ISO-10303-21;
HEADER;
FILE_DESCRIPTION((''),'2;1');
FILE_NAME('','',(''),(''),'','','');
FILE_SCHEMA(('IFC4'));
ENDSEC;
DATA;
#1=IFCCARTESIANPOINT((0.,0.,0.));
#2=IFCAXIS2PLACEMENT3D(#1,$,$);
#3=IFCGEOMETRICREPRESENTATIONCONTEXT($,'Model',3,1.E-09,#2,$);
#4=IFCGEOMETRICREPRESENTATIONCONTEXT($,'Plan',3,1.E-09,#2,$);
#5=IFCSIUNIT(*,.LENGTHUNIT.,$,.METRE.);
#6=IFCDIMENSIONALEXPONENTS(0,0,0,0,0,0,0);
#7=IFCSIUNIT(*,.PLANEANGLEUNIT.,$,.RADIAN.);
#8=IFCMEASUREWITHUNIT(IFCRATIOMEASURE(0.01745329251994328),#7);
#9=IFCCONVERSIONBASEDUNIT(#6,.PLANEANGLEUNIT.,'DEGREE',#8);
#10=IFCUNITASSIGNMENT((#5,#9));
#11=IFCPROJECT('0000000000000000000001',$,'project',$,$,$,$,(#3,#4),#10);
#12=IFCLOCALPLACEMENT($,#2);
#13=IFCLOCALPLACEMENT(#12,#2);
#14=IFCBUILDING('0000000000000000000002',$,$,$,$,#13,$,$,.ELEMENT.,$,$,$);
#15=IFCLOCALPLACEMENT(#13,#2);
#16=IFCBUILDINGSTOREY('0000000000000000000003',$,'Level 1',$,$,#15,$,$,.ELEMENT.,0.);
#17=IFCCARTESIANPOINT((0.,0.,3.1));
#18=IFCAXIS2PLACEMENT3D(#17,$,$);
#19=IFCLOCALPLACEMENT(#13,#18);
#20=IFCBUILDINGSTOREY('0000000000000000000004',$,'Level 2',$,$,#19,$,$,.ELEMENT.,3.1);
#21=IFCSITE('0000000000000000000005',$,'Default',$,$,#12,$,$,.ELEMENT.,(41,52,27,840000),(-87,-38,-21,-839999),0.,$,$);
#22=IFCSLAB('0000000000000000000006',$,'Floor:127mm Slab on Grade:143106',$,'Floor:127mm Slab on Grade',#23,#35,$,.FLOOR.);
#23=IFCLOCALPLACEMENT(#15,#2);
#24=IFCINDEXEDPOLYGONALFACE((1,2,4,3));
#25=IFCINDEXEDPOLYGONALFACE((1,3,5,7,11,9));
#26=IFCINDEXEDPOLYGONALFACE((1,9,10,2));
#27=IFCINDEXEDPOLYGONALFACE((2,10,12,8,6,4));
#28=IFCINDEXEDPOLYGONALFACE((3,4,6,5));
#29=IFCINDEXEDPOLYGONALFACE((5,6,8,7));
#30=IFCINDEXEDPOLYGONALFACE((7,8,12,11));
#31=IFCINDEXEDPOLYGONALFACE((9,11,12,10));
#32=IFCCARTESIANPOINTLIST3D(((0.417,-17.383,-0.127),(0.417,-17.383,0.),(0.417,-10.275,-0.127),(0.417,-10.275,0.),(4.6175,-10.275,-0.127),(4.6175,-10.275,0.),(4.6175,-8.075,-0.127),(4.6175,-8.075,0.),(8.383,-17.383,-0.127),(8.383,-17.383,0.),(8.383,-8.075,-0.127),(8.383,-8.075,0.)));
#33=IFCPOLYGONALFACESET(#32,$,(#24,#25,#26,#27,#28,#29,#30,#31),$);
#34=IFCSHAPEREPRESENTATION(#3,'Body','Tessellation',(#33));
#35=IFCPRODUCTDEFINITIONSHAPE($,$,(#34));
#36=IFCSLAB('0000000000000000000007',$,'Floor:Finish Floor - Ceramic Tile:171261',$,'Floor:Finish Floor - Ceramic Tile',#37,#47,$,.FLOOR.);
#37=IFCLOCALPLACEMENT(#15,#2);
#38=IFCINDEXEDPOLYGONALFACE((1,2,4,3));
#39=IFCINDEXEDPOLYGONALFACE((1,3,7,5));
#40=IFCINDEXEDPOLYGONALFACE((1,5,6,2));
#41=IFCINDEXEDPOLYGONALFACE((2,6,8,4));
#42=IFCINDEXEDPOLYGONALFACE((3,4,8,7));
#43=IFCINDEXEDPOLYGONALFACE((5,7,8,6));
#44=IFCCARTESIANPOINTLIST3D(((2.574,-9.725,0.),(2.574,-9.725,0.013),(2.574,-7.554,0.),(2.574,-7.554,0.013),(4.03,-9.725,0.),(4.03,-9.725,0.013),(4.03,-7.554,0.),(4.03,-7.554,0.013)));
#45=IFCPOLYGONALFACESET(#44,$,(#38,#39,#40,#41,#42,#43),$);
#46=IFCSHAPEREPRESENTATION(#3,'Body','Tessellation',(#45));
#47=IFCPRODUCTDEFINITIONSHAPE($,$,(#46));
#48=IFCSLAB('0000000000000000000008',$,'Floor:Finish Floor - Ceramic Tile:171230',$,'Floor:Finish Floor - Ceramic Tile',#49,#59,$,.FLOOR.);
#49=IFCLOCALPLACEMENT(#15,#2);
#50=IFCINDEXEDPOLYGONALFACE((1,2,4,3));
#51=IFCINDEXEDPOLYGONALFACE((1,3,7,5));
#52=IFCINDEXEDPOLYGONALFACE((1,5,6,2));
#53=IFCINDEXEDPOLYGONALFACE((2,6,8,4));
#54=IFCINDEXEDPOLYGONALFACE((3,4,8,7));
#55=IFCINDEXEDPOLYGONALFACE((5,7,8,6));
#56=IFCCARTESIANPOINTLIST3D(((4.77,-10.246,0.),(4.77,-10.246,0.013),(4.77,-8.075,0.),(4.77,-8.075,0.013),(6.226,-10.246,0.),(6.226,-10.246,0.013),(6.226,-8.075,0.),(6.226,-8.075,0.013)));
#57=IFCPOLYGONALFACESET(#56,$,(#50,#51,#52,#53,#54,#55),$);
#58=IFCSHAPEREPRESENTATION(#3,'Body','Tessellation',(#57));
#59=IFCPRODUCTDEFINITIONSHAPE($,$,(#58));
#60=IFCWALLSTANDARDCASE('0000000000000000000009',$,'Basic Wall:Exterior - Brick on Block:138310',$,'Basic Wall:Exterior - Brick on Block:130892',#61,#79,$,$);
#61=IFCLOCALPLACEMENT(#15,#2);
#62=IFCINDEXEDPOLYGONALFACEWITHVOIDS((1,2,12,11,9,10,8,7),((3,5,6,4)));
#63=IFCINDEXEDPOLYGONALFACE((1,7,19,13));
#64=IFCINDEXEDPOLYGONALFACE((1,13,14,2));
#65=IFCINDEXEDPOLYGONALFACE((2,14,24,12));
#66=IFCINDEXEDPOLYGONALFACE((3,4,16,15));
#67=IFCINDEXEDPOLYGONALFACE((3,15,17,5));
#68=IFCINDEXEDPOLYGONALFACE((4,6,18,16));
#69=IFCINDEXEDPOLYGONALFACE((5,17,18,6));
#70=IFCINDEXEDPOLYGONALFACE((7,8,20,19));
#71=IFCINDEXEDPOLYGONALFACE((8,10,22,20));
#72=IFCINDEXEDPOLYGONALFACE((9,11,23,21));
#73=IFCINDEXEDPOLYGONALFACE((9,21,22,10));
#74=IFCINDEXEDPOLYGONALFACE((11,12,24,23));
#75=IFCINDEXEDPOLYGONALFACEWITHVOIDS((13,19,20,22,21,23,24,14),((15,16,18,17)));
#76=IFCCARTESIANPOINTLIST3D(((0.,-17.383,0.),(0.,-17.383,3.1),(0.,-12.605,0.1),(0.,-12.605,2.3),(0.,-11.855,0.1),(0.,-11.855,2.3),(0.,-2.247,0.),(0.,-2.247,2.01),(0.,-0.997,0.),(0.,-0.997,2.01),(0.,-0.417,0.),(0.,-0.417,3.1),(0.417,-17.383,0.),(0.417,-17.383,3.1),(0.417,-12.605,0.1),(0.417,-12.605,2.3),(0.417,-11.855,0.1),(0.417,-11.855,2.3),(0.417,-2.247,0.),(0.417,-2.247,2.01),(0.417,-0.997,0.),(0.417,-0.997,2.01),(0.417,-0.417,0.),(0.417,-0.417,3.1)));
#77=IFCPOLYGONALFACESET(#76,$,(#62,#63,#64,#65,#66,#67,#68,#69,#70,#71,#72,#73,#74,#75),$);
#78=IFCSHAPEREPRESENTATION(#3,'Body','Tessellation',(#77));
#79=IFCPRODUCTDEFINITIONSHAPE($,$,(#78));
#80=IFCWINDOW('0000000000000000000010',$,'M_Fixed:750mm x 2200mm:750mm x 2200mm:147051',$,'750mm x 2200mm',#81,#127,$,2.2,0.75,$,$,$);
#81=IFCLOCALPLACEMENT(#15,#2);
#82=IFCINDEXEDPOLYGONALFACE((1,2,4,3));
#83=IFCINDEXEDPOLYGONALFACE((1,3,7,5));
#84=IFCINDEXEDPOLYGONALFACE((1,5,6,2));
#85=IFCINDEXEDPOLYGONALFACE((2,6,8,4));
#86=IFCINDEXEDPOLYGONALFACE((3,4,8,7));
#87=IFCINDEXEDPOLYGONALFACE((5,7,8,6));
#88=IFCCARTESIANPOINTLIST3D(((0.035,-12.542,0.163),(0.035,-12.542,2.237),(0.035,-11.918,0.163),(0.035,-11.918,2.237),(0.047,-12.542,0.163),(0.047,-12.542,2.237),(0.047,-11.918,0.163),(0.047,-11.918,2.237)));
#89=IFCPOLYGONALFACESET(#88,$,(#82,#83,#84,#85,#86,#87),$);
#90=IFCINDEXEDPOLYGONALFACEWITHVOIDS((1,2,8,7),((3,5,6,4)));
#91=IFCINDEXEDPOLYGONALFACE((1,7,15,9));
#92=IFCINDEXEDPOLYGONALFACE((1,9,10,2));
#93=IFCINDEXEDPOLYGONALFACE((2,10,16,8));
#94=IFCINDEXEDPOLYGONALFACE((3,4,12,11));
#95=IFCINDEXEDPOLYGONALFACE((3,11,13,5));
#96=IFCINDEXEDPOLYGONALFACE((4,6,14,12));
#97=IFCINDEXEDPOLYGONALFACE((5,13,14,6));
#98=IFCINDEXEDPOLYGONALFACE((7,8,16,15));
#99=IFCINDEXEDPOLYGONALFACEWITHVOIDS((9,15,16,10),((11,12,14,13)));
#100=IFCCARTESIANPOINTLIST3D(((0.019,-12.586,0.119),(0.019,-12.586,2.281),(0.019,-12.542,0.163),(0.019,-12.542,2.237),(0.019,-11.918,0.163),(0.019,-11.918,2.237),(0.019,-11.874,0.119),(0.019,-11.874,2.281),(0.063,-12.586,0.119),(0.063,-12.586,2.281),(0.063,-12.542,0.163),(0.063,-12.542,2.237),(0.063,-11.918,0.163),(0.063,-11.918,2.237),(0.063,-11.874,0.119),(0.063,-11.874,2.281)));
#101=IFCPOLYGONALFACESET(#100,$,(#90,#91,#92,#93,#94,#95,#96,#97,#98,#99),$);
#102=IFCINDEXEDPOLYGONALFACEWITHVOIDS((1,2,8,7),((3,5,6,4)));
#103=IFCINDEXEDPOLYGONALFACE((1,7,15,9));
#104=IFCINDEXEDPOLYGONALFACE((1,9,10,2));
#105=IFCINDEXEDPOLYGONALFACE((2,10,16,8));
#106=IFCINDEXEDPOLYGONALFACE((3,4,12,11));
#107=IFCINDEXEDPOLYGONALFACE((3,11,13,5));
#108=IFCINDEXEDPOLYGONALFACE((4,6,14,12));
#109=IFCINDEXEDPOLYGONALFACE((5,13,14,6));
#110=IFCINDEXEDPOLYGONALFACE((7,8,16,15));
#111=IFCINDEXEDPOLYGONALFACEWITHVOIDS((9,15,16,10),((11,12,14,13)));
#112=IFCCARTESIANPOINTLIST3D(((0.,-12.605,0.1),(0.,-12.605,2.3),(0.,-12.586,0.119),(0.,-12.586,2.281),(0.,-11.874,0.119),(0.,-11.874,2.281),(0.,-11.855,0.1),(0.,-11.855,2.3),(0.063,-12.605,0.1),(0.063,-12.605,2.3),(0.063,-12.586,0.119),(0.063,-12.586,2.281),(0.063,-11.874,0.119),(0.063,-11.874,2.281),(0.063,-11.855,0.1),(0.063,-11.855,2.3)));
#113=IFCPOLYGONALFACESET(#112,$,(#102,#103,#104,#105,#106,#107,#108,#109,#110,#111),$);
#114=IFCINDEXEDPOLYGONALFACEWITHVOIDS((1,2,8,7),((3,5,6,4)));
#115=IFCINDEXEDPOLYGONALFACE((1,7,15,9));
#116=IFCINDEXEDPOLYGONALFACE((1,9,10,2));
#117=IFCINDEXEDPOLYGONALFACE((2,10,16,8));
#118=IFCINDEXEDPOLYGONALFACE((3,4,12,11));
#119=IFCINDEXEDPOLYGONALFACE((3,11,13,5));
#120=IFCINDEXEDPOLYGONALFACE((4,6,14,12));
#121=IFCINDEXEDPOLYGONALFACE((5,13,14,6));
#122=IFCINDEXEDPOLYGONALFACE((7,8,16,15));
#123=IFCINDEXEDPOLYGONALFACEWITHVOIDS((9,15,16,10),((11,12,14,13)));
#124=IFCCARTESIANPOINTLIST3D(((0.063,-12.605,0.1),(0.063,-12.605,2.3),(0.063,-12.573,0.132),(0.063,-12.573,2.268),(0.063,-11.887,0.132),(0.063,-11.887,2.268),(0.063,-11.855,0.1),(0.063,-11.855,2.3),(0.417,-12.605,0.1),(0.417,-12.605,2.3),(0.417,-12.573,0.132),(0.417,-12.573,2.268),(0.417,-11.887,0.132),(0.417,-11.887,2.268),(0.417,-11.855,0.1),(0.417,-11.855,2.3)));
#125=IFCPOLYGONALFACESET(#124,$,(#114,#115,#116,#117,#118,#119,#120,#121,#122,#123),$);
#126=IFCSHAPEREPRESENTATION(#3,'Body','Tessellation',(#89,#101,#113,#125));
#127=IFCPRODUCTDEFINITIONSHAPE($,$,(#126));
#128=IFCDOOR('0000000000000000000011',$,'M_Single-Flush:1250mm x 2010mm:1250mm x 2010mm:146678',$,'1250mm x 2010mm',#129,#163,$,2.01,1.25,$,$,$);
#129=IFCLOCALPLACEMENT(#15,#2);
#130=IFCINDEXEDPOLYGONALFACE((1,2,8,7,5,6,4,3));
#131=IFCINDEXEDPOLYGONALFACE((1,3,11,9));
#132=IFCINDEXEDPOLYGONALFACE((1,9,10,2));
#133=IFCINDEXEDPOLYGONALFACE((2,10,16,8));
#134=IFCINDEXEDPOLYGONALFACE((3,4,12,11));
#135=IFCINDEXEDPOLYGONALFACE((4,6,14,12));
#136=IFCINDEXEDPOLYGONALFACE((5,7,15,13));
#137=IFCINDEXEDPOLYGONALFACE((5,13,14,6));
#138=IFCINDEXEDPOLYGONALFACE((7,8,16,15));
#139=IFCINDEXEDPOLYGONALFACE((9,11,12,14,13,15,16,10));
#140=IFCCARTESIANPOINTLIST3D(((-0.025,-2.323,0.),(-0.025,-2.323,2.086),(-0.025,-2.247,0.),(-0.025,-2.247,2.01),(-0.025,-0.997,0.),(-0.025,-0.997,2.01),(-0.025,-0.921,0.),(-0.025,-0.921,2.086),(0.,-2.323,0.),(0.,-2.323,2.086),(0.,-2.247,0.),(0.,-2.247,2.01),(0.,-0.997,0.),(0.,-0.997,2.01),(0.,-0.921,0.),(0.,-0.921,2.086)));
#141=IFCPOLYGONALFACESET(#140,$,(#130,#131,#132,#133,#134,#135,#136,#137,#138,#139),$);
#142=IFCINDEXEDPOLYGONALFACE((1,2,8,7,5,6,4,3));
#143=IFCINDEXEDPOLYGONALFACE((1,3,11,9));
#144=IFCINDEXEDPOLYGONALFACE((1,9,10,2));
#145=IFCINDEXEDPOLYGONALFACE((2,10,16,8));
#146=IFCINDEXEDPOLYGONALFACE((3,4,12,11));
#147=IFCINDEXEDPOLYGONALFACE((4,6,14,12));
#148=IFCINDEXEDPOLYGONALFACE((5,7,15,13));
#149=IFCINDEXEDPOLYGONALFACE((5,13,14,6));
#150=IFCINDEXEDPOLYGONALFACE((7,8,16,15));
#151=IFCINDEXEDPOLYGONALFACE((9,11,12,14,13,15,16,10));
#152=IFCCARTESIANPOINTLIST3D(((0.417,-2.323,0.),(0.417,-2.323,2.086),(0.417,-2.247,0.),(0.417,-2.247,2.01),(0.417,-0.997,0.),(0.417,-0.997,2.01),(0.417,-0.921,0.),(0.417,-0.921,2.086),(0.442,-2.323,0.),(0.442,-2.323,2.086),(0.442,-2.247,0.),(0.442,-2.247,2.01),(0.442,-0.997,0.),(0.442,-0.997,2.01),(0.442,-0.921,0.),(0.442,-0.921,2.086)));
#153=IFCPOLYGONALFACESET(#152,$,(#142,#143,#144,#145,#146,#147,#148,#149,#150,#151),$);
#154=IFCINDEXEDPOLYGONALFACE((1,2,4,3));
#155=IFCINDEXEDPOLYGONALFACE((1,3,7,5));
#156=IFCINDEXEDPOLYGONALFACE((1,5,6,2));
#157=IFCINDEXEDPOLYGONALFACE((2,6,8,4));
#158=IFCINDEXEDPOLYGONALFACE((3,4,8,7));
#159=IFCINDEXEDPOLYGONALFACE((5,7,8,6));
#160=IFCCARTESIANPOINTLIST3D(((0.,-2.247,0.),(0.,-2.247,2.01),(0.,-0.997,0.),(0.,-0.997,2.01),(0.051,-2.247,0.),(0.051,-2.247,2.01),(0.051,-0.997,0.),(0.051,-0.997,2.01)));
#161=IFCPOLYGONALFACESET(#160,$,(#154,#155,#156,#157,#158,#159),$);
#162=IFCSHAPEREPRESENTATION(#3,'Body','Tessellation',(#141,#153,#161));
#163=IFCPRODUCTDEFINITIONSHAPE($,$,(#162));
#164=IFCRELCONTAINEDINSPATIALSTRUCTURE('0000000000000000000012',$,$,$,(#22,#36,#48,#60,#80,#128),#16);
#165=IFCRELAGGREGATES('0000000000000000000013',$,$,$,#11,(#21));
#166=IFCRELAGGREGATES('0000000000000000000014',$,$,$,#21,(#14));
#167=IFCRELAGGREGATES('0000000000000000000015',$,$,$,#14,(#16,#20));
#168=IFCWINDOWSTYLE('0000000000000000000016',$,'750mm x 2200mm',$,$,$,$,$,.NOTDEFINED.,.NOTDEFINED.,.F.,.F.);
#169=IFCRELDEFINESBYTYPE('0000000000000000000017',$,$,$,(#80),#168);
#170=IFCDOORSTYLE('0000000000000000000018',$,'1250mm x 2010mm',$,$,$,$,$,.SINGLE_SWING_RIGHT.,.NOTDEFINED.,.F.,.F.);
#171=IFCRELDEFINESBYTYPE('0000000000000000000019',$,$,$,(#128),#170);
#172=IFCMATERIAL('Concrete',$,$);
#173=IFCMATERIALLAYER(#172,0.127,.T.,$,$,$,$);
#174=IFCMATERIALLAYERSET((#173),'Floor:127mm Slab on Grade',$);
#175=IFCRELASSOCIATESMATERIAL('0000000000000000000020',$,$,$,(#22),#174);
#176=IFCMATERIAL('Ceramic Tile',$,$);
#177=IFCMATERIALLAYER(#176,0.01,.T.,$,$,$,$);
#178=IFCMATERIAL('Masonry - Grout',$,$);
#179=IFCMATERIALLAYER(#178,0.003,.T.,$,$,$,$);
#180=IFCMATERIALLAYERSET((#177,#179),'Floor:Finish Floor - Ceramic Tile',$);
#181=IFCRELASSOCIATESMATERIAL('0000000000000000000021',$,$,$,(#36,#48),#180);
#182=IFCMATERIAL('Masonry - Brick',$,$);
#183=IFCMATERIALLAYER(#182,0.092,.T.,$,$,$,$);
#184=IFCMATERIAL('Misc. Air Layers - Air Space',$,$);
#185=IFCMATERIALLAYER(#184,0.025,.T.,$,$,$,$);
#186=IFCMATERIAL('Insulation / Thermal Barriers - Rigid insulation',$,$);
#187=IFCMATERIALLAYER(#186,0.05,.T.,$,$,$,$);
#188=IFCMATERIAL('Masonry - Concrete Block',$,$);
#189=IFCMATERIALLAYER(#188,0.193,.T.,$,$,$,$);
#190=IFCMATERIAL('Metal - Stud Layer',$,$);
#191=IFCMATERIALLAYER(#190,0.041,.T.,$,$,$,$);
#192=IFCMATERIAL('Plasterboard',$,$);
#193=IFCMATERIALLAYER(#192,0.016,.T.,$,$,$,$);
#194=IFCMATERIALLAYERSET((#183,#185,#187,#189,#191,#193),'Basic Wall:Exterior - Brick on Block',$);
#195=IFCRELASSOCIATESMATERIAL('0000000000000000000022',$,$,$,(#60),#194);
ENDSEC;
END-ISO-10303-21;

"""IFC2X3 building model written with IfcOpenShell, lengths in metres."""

from ifc_helpers import new_model, entity, si_unit, converted_unit, frame, frame_2d, origin, origin_2d_with_axis, place, context, project, spatial, polyline, rectangle, outline, extrude, source, transform, mapped, material, layer, layer_set, layer_usage, type_object, type_shapes, element, fill, save


model = new_model("IFC2X3")

# Units and contexts
model_context = context("Model", 3, precision=1e-09, world=origin())
plan_context = context("Plan", 3, precision=1e-09, world=origin())
ifc_project = project(units=[si_unit("LENGTHUNIT", "METRE"), converted_unit("PLANEANGLEUNIT", "DEGREE", entity("IfcRatioMeasure", 0.01745329251994328), si_unit("PLANEANGLEUNIT", "RADIAN"), dimensions=[0, 0, 0, 0, 0, 0, 0])], contexts=[model_context, plan_context])

# Site, building, storey
site_placement = place(None, origin())
site = spatial("IfcSite", under=ifc_project, at=site_placement, Name="Default", CompositionType="ELEMENT", RefLatitude=(41, 52, 27, 840000), RefLongitude=(-87, -38, -21, -839999), RefElevation=0.0)
building_placement = place(site_placement, origin())
building = spatial("IfcBuilding", under=site, at=building_placement, CompositionType="ELEMENT")
storey_1_placement = place(building_placement, origin())
storey_1 = spatial("IfcBuildingStorey", under=building, at=storey_1_placement, Name="Level 1", CompositionType="ELEMENT", Elevation=0.0)

# Slabs
ifc_material_1 = material(Name="Concrete")
ifc_layer_1 = layer(ifc_material_1, 0.127, ventilated=True)
ifc_layer_set_1 = layer_set([ifc_layer_1], Name="Floor:127mm Slab on Grade")
ifc_layer_usage_1 = layer_usage(ifc_layer_set_1, "AXIS3", "POSITIVE", 0.0)
ifc_material_2 = material(Name="Ceramic Tile")
ifc_layer_2 = layer(ifc_material_2, 0.01, ventilated=True)
ifc_material_3 = material(Name="Masonry - Grout")
ifc_layer_3 = layer(ifc_material_3, 0.003, ventilated=True)
ifc_layer_set_2 = layer_set([ifc_layer_2, ifc_layer_3], Name="Floor:Finish Floor - Ceramic Tile")
ifc_layer_usage_2 = layer_usage(ifc_layer_set_2, "AXIS3", "POSITIVE", 0.0)
slab_1_placement = place(storey_1_placement, frame((0.417, -17.383, -0.127)))
element("IfcSlab", 1, at=slab_1_placement, inside=storey_1, material=ifc_layer_usage_1, Name="Floor:127mm Slab on Grade:143106", ObjectType="Floor:127mm Slab on Grade", PredefinedType="FLOOR", context=model_context, shape_type="SweptSolid", body=[
    extrude(outline(polyline([(-3.983, 4.654), (-3.983, -4.654), (3.983, -4.654), (3.983, 2.454), (-0.2175, 2.454), (-0.2175, 4.654), (-3.983, 4.654)])), frame((3.983, 4.654, 0.127), z_axis=(0.0, 0.0, -1.0), x_axis=(-1.0, 0.0, 0.0)), (0.0, 0.0, 1.0), 0.127),
])
slab_2_placement = place(storey_1_placement, frame((2.574, -9.725, 0.0)))
element("IfcSlab", 2, at=slab_2_placement, inside=storey_1, material=ifc_layer_usage_2, Name="Floor:Finish Floor - Ceramic Tile:171261", ObjectType="Floor:Finish Floor - Ceramic Tile", PredefinedType="FLOOR", context=model_context, shape_type="SweptSolid", body=[
    extrude(rectangle(XDim=2.171, YDim=1.456, at=frame_2d((0.0, 0.0), x_axis=(0.0, -1.0))), frame((0.728, 1.0855, 0.013), z_axis=(0.0, 0.0, -1.0), x_axis=(-1.0, 0.0, 0.0)), (0.0, 0.0, 1.0), 0.013),
])
slab_3_placement = place(storey_1_placement, frame((4.77, -10.246, 0.0)))
element("IfcSlab", 3, at=slab_3_placement, inside=storey_1, material=ifc_layer_usage_2, Name="Floor:Finish Floor - Ceramic Tile:171230", ObjectType="Floor:Finish Floor - Ceramic Tile", PredefinedType="FLOOR", context=model_context, shape_type="SweptSolid", body=[
    extrude(rectangle(XDim=1.456, YDim=2.171, at=frame_2d((0.0, 0.0), x_axis=(-1.0, 0.0))), frame((0.728, 1.0855, 0.013), z_axis=(0.0, 0.0, -1.0), x_axis=(-1.0, 0.0, 0.0)), (0.0, 0.0, 1.0), 0.013),
])

# Wall, openings, window, door
ifc_material_4 = material(Name="Masonry - Brick")
ifc_layer_4 = layer(ifc_material_4, 0.092, ventilated=True)
ifc_material_5 = material(Name="Misc. Air Layers - Air Space")
ifc_layer_5 = layer(ifc_material_5, 0.025, ventilated=True)
ifc_material_6 = material(Name="Insulation / Thermal Barriers - Rigid insulation")
ifc_layer_6 = layer(ifc_material_6, 0.05, ventilated=True)
ifc_material_7 = material(Name="Masonry - Concrete Block")
ifc_layer_7 = layer(ifc_material_7, 0.193, ventilated=True)
ifc_material_8 = material(Name="Metal - Stud Layer")
ifc_layer_8 = layer(ifc_material_8, 0.041, ventilated=True)
ifc_material_9 = material(Name="Plasterboard")
ifc_layer_9 = layer(ifc_material_9, 0.016, ventilated=True)
ifc_layer_set_3 = layer_set([ifc_layer_4, ifc_layer_5, ifc_layer_6, ifc_layer_7, ifc_layer_8, ifc_layer_9], Name="Basic Wall:Exterior - Brick on Block")
ifc_layer_usage_3 = layer_usage(ifc_layer_set_3, "AXIS2", "NEGATIVE", 0.2085)
wall_1_placement = place(storey_1_placement, frame((0.2085, -17.383, 0.0), z_axis=(0.0, 0.0, 1.0), x_axis=(0.0, 1.0, 0.0)))
wall_1 = element("IfcWallStandardCase", 4, at=wall_1_placement, inside=storey_1, material=ifc_layer_usage_3, Name="Basic Wall:Exterior - Brick on Block:138310", ObjectType="Basic Wall:Exterior - Brick on Block:130892", context=model_context, shape_type="SweptSolid", body=[
    extrude(rectangle(XDim=16.966, YDim=0.417, at=frame_2d((8.483, 0.0), x_axis=(-1.0, 0.0))), origin(), (0.0, 0.0, 1.0), 3.1),
])
opening_1_placement = place(wall_1_placement, frame((15.136, -0.2085, 0.0)))
opening_1 = element("IfcOpeningElement", 5, at=opening_1_placement, cuts=wall_1, ObjectType="Opening", context=model_context, shape_type="SweptSolid", body=[
    extrude(rectangle(XDim=1.25, YDim=2.01, at=frame_2d((1.005, 0.625), x_axis=(0.0, 1.0))), frame((0.0, 0.0, 0.0), z_axis=(0.0, 1.0, 0.0), x_axis=(0.0, 0.0, 1.0)), (0.0, 0.0, 1.0), 0.417),
])
opening_2_placement = place(wall_1_placement, frame((4.778, -0.2085, 0.1)))
opening_2 = element("IfcOpeningElement", 6, at=opening_2_placement, cuts=wall_1, ObjectType="Opening", context=model_context, shape_type="SweptSolid", body=[
    extrude(rectangle(XDim=2.2, YDim=0.75, at=frame_2d((1.1, 0.375), x_axis=(1.0, 0.0))), frame((0.0, 0.0, 0.0), z_axis=(0.0, 1.0, 0.0), x_axis=(0.0, 0.0, 1.0)), (0.0, 0.0, 1.0), 0.417),
])
window_style_1 = type_object("IfcWindowStyle", Name="750mm x 2200mm", ConstructionType="NOTDEFINED", OperationType="NOTDEFINED", ParameterTakesPrecedence=False, Sizeable=False)
shared_shape_1 = source(origin(), model_context, "Body", "SweptSolid", [
    extrude(rectangle(XDim=0.012, YDim=0.624, at=origin_2d_with_axis()), frame((0.375, 0.376, 0.063), z_axis=(0.0, 0.0, 1.0), x_axis=(0.0, -1.0, 0.0)), (0.0, 0.0, 1.0), 2.074),
    extrude(outline(polyline([(-0.356, -1.081), (0.356, -1.081), (0.356, 1.081), (-0.356, 1.081), (-0.356, -1.081)]), holes=[polyline([(-0.312, -1.037), (-0.312, 1.037), (0.312, 1.037), (0.312, -1.037), (-0.312, -1.037)])]), frame((0.375, 0.354, 1.1), z_axis=(0.0, 1.0, 0.0), x_axis=(1.0, 0.0, 0.0)), (0.0, 0.0, 1.0), 0.044),
    extrude(outline(polyline([(-0.375, -1.1), (0.375, -1.1), (0.375, 1.1), (-0.375, 1.1), (-0.375, -1.1)]), holes=[polyline([(-0.356, -1.081), (-0.356, 1.081), (0.356, 1.081), (0.356, -1.081), (-0.356, -1.081)])]), frame((0.375, 0.354, 1.1), z_axis=(0.0, 1.0, 0.0), x_axis=(1.0, 0.0, 0.0)), (0.0, 0.0, 1.0), 0.063),
    extrude(outline(polyline([(-0.375, -1.1), (0.375, -1.1), (0.375, 1.1), (-0.375, 1.1), (-0.375, -1.1)]), holes=[polyline([(-0.343, -1.068), (-0.343, 1.068), (0.343, 1.068), (0.343, -1.068), (-0.343, -1.068)])]), frame((0.375, 0.0, 1.1), z_axis=(0.0, 1.0, 0.0), x_axis=(1.0, 0.0, 0.0)), (0.0, 0.0, 1.0), 0.354),
])
type_shapes(window_style_1, [shared_shape_1])
window_1_placement = place(opening_2_placement, origin())
window_1 = element("IfcWindow", 7, at=window_1_placement, inside=storey_1, type_object=window_style_1, Name="M_Fixed:750mm x 2200mm:750mm x 2200mm:147051", ObjectType="750mm x 2200mm", OverallHeight=2.2, OverallWidth=0.75, context=model_context, shape_type="MappedRepresentation", body=[
    mapped(shared_shape_1, transform((0.0, 0.0, 0.0), scale=1.0)),
])
fill(opening_2, window_1)
door_style_1 = type_object("IfcDoorStyle", Name="1250mm x 2010mm", ConstructionType="NOTDEFINED", OperationType="SINGLE_SWING_RIGHT", ParameterTakesPrecedence=False, Sizeable=False)
shared_shape_2 = source(origin(), model_context, "Body", "SweptSolid", [
    extrude(outline(polyline([(-0.701, -1.062), (0.701, -1.062), (0.701, 1.024), (0.625, 1.024), (0.625, -0.986), (-0.625, -0.986), (-0.625, 1.024), (-0.701, 1.024), (-0.701, -1.062)])), frame((0.625, 0.417, 1.024), z_axis=(0.0, 1.0, 0.0), x_axis=(1.0, 0.0, 0.0)), (0.0, 0.0, 1.0), 0.025),
    extrude(outline(polyline([(-1.062, -0.701), (1.024, -0.701), (1.024, -0.625), (-0.986, -0.625), (-0.986, 0.625), (1.024, 0.625), (1.024, 0.701), (-1.062, 0.701), (-1.062, -0.701)])), frame((0.625, -0.025, 1.024), z_axis=(0.0, 1.0, 0.0), x_axis=(0.0, 0.0, -1.0)), (0.0, 0.0, 1.0), 0.025),
    extrude(rectangle(XDim=0.051, YDim=1.25, at=origin_2d_with_axis()), frame((0.625, 0.3915, 0.0), z_axis=(0.0, 0.0, 1.0), x_axis=(0.0, 1.0, 0.0)), (0.0, 0.0, 1.0), 2.01),
])
type_shapes(door_style_1, [shared_shape_2])
door_1_placement = place(opening_1_placement, origin())
door_1 = element("IfcDoor", 8, at=door_1_placement, inside=storey_1, type_object=door_style_1, Name="M_Single-Flush:1250mm x 2010mm:1250mm x 2010mm:146678", ObjectType="1250mm x 2010mm", OverallHeight=2.01, OverallWidth=1.25, context=model_context, shape_type="MappedRepresentation", body=[
    mapped(shared_shape_2, transform((0.0, 0.0, 0.0), scale=1.0)),
])
fill(opening_1, door_1)

# Shared definitions
storey_2_placement = place(building_placement, frame((0.0, 0.0, 3.1)))
storey_2 = spatial("IfcBuildingStorey", under=building, at=storey_2_placement, Name="Level 2", CompositionType="ELEMENT", Elevation=3.1)

save(model, "model.ifc")
